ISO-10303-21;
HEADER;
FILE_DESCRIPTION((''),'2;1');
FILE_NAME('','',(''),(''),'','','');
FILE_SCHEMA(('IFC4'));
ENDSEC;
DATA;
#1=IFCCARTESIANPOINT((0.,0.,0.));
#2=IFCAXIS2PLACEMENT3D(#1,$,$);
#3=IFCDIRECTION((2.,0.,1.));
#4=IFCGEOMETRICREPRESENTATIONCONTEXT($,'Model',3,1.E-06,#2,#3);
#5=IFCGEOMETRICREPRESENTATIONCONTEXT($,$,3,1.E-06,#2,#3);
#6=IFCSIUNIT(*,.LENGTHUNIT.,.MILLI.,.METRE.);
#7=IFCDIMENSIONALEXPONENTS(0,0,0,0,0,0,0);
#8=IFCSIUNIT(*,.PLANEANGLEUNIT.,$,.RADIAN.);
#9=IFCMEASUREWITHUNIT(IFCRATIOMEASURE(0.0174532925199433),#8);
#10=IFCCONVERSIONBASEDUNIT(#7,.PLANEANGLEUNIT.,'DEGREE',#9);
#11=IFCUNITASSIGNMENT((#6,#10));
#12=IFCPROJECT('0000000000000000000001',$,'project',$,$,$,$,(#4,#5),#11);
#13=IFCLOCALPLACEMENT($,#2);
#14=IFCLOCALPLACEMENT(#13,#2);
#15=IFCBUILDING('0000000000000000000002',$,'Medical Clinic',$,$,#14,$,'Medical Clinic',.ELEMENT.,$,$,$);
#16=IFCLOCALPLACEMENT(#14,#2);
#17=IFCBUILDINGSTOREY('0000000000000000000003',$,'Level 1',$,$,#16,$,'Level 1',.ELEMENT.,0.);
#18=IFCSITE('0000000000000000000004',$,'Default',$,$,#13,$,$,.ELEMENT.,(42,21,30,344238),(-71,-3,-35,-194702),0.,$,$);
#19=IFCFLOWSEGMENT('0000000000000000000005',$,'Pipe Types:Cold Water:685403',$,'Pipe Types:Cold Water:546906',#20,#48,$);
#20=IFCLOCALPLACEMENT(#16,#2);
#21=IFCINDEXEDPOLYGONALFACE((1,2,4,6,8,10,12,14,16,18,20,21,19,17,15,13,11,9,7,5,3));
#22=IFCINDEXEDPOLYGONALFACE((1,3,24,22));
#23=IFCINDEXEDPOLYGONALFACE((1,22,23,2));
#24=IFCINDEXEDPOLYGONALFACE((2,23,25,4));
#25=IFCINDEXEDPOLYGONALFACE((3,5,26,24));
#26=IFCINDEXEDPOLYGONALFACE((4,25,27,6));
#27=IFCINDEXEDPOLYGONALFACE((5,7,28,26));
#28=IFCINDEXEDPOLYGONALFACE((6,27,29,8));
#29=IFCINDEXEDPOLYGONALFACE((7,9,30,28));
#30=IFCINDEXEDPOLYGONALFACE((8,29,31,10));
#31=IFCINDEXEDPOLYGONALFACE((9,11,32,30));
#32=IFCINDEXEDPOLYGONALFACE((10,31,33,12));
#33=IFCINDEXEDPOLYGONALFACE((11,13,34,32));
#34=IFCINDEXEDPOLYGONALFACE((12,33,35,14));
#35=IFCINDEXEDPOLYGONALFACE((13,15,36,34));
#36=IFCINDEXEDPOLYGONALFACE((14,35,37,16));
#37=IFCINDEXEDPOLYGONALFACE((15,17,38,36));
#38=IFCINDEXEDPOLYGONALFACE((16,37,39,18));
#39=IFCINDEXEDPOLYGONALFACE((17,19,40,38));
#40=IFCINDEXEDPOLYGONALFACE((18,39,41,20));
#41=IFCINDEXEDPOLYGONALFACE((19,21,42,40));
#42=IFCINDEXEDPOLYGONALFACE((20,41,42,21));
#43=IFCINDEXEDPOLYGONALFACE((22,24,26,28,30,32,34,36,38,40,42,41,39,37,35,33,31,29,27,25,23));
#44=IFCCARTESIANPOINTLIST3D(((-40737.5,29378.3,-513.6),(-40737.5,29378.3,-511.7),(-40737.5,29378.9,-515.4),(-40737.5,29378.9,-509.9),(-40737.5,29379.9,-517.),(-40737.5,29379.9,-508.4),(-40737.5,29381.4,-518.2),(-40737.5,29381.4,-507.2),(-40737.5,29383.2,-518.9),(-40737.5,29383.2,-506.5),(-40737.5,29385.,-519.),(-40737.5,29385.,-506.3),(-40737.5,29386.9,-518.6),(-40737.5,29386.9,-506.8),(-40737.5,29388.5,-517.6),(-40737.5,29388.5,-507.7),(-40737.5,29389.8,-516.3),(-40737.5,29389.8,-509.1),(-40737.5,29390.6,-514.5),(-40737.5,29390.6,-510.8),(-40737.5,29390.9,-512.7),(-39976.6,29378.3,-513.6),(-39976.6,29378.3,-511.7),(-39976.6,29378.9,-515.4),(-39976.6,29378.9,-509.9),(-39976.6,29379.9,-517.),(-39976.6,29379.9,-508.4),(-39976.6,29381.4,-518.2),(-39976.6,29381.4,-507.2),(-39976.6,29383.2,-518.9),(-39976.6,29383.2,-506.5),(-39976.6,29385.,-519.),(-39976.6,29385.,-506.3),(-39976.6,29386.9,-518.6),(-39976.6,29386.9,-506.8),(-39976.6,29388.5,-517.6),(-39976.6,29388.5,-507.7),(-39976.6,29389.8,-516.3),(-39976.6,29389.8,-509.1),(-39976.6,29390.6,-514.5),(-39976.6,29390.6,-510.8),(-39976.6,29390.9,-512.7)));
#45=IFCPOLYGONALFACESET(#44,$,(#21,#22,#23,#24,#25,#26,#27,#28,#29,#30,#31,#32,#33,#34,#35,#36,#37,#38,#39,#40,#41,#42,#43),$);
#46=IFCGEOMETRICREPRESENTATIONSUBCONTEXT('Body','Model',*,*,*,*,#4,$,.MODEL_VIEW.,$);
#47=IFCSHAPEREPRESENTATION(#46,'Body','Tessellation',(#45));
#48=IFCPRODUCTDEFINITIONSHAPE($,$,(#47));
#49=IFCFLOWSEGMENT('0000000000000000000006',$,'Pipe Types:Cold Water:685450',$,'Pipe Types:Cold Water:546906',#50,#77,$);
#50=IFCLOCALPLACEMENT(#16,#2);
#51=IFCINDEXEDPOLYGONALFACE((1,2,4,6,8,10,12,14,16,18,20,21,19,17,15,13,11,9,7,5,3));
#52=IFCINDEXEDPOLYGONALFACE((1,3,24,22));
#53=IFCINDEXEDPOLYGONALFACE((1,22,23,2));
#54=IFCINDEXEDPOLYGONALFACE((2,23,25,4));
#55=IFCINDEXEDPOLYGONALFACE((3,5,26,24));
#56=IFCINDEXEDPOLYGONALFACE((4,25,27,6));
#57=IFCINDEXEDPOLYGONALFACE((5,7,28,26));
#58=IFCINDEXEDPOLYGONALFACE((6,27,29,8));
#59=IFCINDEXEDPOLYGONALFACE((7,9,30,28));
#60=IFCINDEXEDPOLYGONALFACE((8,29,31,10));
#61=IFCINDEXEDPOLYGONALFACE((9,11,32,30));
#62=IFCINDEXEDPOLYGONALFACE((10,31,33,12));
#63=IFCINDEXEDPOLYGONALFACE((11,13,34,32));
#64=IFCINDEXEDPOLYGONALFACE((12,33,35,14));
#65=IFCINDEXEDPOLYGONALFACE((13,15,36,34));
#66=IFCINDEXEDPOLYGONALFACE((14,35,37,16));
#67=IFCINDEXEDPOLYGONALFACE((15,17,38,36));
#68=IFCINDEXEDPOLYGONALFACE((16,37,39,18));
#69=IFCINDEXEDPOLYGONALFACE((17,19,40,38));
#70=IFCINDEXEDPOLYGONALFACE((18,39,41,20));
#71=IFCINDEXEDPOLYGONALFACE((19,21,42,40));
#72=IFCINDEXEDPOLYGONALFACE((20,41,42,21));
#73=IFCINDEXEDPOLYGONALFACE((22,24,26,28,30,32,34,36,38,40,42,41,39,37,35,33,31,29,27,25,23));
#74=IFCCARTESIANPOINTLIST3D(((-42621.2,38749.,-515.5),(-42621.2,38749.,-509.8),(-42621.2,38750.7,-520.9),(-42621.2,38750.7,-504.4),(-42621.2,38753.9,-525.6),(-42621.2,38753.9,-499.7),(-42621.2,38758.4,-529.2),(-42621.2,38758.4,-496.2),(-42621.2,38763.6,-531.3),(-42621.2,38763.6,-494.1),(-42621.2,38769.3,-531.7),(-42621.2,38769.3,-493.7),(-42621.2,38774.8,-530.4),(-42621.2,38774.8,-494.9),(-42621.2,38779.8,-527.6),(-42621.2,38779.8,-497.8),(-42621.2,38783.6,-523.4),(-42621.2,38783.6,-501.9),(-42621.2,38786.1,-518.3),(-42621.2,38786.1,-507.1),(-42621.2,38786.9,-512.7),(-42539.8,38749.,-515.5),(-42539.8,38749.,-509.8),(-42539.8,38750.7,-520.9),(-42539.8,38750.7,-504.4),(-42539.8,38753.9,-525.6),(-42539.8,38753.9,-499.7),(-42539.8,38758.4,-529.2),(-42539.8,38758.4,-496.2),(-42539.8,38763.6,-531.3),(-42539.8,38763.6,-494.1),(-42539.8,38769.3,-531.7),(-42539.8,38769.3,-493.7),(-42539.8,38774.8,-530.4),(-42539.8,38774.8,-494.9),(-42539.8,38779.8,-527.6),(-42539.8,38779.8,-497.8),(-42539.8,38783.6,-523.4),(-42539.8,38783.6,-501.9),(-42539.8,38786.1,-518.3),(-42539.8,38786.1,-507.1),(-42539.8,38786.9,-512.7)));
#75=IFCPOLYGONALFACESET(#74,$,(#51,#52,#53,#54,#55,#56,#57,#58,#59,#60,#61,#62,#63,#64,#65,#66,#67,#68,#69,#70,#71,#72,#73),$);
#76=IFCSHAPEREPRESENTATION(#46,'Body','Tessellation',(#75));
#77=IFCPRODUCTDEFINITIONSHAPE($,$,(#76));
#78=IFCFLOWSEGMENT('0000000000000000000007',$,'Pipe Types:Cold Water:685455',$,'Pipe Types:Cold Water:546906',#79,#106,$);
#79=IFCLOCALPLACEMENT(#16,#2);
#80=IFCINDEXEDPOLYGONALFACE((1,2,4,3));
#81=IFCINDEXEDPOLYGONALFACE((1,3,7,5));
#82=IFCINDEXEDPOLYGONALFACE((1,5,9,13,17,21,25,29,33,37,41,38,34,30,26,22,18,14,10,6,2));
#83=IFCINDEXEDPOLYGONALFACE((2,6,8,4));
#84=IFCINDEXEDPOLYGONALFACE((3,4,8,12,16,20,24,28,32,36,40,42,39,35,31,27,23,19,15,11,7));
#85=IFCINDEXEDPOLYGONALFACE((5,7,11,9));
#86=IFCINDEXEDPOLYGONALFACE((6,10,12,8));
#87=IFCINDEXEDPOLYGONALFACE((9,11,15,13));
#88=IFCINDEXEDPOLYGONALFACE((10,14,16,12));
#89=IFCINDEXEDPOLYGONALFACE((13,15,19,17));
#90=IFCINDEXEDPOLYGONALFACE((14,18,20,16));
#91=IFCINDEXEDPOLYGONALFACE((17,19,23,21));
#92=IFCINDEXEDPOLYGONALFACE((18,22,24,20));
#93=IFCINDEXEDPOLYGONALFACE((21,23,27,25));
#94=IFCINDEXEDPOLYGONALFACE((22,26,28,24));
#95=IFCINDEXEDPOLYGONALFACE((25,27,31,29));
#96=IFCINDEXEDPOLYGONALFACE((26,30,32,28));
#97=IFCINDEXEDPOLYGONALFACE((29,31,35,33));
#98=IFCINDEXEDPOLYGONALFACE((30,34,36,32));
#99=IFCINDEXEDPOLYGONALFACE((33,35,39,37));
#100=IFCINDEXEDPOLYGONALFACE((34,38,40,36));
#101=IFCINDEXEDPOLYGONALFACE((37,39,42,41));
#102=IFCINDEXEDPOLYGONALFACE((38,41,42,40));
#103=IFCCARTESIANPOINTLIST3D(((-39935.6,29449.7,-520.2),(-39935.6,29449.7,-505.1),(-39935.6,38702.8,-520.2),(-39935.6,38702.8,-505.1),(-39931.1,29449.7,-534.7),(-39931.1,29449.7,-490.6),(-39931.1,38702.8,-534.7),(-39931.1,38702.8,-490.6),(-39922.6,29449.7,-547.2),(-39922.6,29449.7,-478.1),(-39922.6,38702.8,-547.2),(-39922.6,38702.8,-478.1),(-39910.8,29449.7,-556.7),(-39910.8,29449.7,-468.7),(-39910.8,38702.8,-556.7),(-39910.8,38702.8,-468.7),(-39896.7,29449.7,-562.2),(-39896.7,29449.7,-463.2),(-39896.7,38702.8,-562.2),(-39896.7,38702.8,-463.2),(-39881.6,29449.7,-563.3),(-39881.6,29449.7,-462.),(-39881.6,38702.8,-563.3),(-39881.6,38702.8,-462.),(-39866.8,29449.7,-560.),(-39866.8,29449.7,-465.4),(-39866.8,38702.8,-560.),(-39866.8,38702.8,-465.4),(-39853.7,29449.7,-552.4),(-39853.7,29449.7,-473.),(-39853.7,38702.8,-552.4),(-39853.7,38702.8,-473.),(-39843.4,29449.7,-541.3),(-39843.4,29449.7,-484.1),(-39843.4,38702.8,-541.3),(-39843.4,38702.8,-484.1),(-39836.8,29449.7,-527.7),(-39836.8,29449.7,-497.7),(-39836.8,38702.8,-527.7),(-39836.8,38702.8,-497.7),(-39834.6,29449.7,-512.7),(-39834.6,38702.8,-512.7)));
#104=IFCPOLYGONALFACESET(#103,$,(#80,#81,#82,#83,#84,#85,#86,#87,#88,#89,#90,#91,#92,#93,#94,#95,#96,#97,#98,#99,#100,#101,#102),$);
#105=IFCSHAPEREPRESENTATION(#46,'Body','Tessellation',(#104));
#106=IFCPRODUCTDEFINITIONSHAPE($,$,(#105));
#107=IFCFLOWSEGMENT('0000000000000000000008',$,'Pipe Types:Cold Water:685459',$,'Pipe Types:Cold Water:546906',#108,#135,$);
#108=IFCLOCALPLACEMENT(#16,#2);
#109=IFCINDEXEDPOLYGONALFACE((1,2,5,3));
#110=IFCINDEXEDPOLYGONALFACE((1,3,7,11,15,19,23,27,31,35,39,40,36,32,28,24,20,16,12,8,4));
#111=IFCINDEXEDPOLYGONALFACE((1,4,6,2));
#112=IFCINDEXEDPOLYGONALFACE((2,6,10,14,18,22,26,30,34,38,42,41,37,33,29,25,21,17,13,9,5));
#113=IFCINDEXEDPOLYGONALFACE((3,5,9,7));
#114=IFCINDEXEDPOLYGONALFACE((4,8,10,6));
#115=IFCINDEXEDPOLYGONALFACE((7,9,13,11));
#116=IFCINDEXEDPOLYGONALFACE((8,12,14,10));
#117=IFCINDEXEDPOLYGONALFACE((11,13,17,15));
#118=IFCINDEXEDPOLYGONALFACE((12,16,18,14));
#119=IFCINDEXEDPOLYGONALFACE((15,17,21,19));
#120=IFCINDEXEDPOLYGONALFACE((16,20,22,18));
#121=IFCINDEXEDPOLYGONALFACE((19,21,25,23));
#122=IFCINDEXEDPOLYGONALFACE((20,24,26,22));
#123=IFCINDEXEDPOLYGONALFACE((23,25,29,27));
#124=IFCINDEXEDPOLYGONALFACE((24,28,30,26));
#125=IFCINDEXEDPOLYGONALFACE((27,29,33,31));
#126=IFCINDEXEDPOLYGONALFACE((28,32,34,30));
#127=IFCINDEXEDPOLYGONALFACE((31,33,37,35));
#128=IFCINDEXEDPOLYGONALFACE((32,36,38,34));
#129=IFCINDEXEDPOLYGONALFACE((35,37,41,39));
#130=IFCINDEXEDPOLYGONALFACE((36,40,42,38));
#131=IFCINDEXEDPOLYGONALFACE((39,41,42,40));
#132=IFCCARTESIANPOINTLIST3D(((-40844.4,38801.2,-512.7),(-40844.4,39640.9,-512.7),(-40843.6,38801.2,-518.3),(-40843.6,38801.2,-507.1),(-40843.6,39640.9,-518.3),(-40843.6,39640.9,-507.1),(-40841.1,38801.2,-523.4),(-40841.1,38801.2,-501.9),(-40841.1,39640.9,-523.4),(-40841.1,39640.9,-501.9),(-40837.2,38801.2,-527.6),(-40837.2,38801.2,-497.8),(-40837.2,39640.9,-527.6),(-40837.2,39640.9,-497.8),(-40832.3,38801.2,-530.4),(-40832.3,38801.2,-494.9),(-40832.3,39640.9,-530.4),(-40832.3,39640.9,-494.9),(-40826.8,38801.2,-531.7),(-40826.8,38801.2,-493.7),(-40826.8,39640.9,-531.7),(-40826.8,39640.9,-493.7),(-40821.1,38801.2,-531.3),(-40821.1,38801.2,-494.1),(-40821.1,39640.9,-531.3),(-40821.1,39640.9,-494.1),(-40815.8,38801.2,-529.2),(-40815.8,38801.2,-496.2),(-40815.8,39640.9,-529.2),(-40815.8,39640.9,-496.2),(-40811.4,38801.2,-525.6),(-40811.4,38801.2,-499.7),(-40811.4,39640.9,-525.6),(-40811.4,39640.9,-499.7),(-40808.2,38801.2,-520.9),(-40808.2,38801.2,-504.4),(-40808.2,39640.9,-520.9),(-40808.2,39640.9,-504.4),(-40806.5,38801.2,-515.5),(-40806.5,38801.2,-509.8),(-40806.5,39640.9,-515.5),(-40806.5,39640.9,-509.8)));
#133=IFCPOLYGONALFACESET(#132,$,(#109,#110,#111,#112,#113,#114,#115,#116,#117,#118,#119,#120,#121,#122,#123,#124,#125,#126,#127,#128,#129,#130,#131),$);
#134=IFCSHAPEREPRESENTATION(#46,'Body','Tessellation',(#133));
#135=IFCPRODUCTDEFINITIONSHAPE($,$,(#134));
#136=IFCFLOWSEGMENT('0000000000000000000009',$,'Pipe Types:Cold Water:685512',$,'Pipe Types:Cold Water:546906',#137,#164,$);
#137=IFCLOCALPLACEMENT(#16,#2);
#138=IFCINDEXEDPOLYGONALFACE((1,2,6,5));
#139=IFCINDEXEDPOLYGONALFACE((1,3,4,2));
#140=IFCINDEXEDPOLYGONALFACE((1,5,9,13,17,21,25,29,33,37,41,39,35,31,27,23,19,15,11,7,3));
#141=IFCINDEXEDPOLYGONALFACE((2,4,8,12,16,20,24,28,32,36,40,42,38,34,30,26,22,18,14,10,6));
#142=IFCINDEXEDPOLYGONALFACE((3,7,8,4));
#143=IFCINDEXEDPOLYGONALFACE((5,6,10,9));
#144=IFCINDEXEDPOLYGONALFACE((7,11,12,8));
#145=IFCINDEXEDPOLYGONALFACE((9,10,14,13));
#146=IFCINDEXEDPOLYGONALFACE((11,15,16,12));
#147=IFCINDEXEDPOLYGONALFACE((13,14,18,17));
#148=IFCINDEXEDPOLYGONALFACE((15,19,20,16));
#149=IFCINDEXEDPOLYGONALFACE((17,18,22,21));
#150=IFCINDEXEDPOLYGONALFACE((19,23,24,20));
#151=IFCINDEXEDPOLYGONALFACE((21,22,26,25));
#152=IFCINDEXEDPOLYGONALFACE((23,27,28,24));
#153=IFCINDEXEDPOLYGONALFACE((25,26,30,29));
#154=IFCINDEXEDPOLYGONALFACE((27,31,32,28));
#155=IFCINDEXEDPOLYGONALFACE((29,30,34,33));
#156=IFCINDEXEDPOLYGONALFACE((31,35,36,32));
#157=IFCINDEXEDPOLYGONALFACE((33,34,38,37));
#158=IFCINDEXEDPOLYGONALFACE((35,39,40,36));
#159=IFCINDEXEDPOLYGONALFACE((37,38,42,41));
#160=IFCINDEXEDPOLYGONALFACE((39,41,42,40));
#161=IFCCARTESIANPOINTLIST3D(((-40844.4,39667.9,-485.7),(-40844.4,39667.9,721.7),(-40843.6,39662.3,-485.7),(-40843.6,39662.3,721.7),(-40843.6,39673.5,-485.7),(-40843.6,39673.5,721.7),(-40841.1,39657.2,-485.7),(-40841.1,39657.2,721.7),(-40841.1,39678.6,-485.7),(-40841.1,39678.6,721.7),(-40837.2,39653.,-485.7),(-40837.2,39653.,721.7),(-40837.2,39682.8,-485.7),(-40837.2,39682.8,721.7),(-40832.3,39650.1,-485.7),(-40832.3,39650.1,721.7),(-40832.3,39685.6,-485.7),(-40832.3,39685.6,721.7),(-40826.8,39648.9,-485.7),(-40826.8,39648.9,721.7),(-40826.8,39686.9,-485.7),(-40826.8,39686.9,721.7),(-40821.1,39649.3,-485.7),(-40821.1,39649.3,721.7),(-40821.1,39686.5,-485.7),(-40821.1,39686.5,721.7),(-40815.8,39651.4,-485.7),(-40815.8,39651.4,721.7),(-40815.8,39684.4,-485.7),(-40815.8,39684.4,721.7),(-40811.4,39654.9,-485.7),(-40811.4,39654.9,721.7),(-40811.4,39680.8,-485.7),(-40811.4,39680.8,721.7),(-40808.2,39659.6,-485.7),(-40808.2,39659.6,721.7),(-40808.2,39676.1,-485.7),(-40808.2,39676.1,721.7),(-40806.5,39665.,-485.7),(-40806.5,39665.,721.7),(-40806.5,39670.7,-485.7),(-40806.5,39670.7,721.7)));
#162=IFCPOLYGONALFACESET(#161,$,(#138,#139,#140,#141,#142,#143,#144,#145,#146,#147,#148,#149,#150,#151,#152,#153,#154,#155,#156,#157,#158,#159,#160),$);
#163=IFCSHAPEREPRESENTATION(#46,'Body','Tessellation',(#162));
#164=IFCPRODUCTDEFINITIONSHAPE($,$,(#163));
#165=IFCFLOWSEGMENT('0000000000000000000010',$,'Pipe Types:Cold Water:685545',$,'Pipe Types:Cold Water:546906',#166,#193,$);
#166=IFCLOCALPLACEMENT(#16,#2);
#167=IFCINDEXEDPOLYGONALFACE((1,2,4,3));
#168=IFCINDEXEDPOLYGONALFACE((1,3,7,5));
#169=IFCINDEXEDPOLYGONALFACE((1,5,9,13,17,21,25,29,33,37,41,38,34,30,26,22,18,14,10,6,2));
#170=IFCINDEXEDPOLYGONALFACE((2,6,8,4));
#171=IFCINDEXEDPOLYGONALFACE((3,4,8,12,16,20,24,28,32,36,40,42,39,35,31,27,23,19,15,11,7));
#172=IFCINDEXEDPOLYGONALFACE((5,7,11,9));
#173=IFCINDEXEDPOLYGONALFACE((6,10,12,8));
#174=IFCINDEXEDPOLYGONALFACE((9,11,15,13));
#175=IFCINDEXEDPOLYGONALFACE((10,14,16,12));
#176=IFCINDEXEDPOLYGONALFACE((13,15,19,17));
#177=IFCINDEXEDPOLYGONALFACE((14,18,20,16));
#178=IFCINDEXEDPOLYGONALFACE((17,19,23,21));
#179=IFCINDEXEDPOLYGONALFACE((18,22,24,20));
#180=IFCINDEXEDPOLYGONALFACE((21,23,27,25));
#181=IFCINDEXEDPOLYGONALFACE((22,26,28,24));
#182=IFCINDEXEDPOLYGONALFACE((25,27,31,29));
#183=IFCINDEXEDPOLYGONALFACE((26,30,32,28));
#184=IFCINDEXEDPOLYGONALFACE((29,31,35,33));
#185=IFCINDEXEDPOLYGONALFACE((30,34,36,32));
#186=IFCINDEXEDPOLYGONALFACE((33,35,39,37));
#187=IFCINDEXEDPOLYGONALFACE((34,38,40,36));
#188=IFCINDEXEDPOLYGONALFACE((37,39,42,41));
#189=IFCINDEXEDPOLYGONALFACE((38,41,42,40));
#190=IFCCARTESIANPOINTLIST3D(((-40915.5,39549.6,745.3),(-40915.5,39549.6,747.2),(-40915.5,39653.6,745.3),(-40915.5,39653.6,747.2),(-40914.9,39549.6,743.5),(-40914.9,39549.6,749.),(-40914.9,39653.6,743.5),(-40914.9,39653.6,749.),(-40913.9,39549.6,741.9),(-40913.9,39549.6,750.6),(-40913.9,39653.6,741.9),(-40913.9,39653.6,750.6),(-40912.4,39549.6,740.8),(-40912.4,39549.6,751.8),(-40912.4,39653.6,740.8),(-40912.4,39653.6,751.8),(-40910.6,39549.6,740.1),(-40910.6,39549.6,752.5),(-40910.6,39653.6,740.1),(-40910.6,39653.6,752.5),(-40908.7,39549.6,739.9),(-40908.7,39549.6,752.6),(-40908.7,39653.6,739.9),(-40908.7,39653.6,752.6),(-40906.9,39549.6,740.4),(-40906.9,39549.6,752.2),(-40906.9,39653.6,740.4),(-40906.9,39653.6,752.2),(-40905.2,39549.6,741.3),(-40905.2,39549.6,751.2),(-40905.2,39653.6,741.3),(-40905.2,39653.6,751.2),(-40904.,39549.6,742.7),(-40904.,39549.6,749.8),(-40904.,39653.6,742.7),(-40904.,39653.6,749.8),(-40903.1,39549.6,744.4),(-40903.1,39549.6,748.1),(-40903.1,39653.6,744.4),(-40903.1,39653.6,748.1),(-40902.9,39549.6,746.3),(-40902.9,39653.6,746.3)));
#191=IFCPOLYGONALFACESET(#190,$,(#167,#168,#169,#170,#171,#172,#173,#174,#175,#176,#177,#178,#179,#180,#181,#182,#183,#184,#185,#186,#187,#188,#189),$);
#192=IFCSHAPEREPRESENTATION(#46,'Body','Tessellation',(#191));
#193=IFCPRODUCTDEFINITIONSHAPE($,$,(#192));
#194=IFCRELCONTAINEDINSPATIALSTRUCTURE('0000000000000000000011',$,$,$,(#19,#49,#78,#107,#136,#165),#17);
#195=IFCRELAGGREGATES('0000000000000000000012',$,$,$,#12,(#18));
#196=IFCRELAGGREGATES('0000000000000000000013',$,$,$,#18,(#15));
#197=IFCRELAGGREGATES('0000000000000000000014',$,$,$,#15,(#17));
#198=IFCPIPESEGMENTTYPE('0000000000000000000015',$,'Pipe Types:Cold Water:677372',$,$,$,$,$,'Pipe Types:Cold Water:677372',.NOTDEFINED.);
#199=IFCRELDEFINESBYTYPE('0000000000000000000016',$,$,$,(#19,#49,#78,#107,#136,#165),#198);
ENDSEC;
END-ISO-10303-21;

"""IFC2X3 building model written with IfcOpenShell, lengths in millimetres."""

from ifc_helpers import new_model, entity, si_unit, converted_unit, direction, frame, frame_2d, origin, origin_2d_with_axis, place, context, subcontext, project, spatial, circle, extrude, type_object, element, save


model = new_model("IFC2X3")

# Units and contexts
model_context = context("Model", 3, precision=1e-06, world=origin(), true_north=direction((2.0, 0.0, 1.0)))
context_of_model = context(None, 3, precision=1e-06, world=origin(), true_north=direction((2.0, 0.0, 1.0)))
body_context = subcontext(model_context, "Body", "Model", "MODEL_VIEW")
ifc_project = project(units=[si_unit("LENGTHUNIT", "METRE", prefix="MILLI"), converted_unit("PLANEANGLEUNIT", "DEGREE", entity("IfcRatioMeasure", 0.0174532925199433), si_unit("PLANEANGLEUNIT", "RADIAN"), dimensions=[0, 0, 0, 0, 0, 0, 0])], contexts=[model_context, context_of_model])

# Site, building, storey
site_placement = place(None, origin())
site = spatial("IfcSite", under=ifc_project, at=site_placement, Name="Default", CompositionType="ELEMENT", RefLatitude=(42, 21, 30, 344238), RefLongitude=(-71, -3, -35, -194702), RefElevation=0.0)
building_placement = place(site_placement, origin())
building = spatial("IfcBuilding", under=site, at=building_placement, Name="Medical Clinic", LongName="Medical Clinic", CompositionType="ELEMENT")
storey_placement = place(building_placement, origin())
storey = spatial("IfcBuildingStorey", under=building, at=storey_placement, Name="Level 1", LongName="Level 1", CompositionType="ELEMENT", Elevation=0.0)

# Flow segments
pipe_segment_type = type_object("IfcPipeSegmentType", Name="Pipe Types:Cold Water:677372", ElementType="Pipe Types:Cold Water:677372", PredefinedType="NOTDEFINED")
flow_segment_1_placement = place(storey_placement, origin())
element("IfcFlowSegment", 1, at=flow_segment_1_placement, inside=storey, type_object=pipe_segment_type, Name="Pipe Types:Cold Water:685403", ObjectType="Pipe Types:Cold Water:546906", context=body_context, shape_type="SweptSolid", body=[
    extrude(circle(Radius=6.3, at=origin_2d_with_axis()), frame((-40737.5, 29384.6, -512.7), z_axis=(1.0, 0.0, 0.0), x_axis=(0.0, 1.0, 0.0)), (0.0, 0.0, 1.0), 760.9),
])
flow_segment_2_placement = place(storey_placement, origin())
element("IfcFlowSegment", 2, at=flow_segment_2_placement, inside=storey, type_object=pipe_segment_type, Name="Pipe Types:Cold Water:685450", ObjectType="Pipe Types:Cold Water:546906", context=body_context, shape_type="SweptSolid", body=[
    extrude(circle(Radius=19.1, at=frame_2d((0.0, 0.0), x_axis=(1.0, 0.0))), frame((-42621.2, 38767.9, -512.7), z_axis=(1.0, 0.0, 0.0), x_axis=(0.0, 1.0, 0.0)), (0.0, 0.0, 1.0), 81.4),
])
flow_segment_3_placement = place(storey_placement, origin())
element("IfcFlowSegment", 3, at=flow_segment_3_placement, inside=storey, type_object=pipe_segment_type, Name="Pipe Types:Cold Water:685455", ObjectType="Pipe Types:Cold Water:546906", context=body_context, shape_type="SweptSolid", body=[
    extrude(circle(Radius=50.8, at=frame_2d((0.0, 0.0), x_axis=(1.0, 0.0))), frame((-39885.4, 29449.7, -512.7), z_axis=(0.0, 1.0, 0.0), x_axis=(1.0, 0.0, 0.0)), (0.0, 0.0, 1.0), 9253.1),
])
flow_segment_4_placement = place(storey_placement, origin())
element("IfcFlowSegment", 4, at=flow_segment_4_placement, inside=storey, type_object=pipe_segment_type, Name="Pipe Types:Cold Water:685459", ObjectType="Pipe Types:Cold Water:546906", context=body_context, shape_type="SweptSolid", body=[
    extrude(circle(Radius=19.1, at=origin_2d_with_axis()), frame((-40825.4, 38801.2, -512.7), z_axis=(0.0, 1.0, 0.0), x_axis=(-1.0, 0.0, 0.0)), (0.0, 0.0, 1.0), 839.7),
])
flow_segment_5_placement = place(storey_placement, origin())
element("IfcFlowSegment", 5, at=flow_segment_5_placement, inside=storey, type_object=pipe_segment_type, Name="Pipe Types:Cold Water:685512", ObjectType="Pipe Types:Cold Water:546906", context=body_context, shape_type="SweptSolid", body=[
    extrude(circle(Radius=19.1, at=origin_2d_with_axis()), frame((-40825.4, 39667.9, -485.7), z_axis=(0.0, 0.0, 1.0), x_axis=(-1.0, 0.0, 0.0)), (0.0, 0.0, 1.0), 1207.3),
])
flow_segment_6_placement = place(storey_placement, origin())
element("IfcFlowSegment", 6, at=flow_segment_6_placement, inside=storey, type_object=pipe_segment_type, Name="Pipe Types:Cold Water:685545", ObjectType="Pipe Types:Cold Water:546906", context=body_context, shape_type="SweptSolid", body=[
    extrude(circle(Radius=6.3, at=origin_2d_with_axis()), frame((-40909.2, 39549.6, 746.3), z_axis=(0.0, 1.0, 0.0), x_axis=(1.0, 0.0, 0.0)), (0.0, 0.0, 1.0), 104.0),
])

save(model, "model.ifc")
